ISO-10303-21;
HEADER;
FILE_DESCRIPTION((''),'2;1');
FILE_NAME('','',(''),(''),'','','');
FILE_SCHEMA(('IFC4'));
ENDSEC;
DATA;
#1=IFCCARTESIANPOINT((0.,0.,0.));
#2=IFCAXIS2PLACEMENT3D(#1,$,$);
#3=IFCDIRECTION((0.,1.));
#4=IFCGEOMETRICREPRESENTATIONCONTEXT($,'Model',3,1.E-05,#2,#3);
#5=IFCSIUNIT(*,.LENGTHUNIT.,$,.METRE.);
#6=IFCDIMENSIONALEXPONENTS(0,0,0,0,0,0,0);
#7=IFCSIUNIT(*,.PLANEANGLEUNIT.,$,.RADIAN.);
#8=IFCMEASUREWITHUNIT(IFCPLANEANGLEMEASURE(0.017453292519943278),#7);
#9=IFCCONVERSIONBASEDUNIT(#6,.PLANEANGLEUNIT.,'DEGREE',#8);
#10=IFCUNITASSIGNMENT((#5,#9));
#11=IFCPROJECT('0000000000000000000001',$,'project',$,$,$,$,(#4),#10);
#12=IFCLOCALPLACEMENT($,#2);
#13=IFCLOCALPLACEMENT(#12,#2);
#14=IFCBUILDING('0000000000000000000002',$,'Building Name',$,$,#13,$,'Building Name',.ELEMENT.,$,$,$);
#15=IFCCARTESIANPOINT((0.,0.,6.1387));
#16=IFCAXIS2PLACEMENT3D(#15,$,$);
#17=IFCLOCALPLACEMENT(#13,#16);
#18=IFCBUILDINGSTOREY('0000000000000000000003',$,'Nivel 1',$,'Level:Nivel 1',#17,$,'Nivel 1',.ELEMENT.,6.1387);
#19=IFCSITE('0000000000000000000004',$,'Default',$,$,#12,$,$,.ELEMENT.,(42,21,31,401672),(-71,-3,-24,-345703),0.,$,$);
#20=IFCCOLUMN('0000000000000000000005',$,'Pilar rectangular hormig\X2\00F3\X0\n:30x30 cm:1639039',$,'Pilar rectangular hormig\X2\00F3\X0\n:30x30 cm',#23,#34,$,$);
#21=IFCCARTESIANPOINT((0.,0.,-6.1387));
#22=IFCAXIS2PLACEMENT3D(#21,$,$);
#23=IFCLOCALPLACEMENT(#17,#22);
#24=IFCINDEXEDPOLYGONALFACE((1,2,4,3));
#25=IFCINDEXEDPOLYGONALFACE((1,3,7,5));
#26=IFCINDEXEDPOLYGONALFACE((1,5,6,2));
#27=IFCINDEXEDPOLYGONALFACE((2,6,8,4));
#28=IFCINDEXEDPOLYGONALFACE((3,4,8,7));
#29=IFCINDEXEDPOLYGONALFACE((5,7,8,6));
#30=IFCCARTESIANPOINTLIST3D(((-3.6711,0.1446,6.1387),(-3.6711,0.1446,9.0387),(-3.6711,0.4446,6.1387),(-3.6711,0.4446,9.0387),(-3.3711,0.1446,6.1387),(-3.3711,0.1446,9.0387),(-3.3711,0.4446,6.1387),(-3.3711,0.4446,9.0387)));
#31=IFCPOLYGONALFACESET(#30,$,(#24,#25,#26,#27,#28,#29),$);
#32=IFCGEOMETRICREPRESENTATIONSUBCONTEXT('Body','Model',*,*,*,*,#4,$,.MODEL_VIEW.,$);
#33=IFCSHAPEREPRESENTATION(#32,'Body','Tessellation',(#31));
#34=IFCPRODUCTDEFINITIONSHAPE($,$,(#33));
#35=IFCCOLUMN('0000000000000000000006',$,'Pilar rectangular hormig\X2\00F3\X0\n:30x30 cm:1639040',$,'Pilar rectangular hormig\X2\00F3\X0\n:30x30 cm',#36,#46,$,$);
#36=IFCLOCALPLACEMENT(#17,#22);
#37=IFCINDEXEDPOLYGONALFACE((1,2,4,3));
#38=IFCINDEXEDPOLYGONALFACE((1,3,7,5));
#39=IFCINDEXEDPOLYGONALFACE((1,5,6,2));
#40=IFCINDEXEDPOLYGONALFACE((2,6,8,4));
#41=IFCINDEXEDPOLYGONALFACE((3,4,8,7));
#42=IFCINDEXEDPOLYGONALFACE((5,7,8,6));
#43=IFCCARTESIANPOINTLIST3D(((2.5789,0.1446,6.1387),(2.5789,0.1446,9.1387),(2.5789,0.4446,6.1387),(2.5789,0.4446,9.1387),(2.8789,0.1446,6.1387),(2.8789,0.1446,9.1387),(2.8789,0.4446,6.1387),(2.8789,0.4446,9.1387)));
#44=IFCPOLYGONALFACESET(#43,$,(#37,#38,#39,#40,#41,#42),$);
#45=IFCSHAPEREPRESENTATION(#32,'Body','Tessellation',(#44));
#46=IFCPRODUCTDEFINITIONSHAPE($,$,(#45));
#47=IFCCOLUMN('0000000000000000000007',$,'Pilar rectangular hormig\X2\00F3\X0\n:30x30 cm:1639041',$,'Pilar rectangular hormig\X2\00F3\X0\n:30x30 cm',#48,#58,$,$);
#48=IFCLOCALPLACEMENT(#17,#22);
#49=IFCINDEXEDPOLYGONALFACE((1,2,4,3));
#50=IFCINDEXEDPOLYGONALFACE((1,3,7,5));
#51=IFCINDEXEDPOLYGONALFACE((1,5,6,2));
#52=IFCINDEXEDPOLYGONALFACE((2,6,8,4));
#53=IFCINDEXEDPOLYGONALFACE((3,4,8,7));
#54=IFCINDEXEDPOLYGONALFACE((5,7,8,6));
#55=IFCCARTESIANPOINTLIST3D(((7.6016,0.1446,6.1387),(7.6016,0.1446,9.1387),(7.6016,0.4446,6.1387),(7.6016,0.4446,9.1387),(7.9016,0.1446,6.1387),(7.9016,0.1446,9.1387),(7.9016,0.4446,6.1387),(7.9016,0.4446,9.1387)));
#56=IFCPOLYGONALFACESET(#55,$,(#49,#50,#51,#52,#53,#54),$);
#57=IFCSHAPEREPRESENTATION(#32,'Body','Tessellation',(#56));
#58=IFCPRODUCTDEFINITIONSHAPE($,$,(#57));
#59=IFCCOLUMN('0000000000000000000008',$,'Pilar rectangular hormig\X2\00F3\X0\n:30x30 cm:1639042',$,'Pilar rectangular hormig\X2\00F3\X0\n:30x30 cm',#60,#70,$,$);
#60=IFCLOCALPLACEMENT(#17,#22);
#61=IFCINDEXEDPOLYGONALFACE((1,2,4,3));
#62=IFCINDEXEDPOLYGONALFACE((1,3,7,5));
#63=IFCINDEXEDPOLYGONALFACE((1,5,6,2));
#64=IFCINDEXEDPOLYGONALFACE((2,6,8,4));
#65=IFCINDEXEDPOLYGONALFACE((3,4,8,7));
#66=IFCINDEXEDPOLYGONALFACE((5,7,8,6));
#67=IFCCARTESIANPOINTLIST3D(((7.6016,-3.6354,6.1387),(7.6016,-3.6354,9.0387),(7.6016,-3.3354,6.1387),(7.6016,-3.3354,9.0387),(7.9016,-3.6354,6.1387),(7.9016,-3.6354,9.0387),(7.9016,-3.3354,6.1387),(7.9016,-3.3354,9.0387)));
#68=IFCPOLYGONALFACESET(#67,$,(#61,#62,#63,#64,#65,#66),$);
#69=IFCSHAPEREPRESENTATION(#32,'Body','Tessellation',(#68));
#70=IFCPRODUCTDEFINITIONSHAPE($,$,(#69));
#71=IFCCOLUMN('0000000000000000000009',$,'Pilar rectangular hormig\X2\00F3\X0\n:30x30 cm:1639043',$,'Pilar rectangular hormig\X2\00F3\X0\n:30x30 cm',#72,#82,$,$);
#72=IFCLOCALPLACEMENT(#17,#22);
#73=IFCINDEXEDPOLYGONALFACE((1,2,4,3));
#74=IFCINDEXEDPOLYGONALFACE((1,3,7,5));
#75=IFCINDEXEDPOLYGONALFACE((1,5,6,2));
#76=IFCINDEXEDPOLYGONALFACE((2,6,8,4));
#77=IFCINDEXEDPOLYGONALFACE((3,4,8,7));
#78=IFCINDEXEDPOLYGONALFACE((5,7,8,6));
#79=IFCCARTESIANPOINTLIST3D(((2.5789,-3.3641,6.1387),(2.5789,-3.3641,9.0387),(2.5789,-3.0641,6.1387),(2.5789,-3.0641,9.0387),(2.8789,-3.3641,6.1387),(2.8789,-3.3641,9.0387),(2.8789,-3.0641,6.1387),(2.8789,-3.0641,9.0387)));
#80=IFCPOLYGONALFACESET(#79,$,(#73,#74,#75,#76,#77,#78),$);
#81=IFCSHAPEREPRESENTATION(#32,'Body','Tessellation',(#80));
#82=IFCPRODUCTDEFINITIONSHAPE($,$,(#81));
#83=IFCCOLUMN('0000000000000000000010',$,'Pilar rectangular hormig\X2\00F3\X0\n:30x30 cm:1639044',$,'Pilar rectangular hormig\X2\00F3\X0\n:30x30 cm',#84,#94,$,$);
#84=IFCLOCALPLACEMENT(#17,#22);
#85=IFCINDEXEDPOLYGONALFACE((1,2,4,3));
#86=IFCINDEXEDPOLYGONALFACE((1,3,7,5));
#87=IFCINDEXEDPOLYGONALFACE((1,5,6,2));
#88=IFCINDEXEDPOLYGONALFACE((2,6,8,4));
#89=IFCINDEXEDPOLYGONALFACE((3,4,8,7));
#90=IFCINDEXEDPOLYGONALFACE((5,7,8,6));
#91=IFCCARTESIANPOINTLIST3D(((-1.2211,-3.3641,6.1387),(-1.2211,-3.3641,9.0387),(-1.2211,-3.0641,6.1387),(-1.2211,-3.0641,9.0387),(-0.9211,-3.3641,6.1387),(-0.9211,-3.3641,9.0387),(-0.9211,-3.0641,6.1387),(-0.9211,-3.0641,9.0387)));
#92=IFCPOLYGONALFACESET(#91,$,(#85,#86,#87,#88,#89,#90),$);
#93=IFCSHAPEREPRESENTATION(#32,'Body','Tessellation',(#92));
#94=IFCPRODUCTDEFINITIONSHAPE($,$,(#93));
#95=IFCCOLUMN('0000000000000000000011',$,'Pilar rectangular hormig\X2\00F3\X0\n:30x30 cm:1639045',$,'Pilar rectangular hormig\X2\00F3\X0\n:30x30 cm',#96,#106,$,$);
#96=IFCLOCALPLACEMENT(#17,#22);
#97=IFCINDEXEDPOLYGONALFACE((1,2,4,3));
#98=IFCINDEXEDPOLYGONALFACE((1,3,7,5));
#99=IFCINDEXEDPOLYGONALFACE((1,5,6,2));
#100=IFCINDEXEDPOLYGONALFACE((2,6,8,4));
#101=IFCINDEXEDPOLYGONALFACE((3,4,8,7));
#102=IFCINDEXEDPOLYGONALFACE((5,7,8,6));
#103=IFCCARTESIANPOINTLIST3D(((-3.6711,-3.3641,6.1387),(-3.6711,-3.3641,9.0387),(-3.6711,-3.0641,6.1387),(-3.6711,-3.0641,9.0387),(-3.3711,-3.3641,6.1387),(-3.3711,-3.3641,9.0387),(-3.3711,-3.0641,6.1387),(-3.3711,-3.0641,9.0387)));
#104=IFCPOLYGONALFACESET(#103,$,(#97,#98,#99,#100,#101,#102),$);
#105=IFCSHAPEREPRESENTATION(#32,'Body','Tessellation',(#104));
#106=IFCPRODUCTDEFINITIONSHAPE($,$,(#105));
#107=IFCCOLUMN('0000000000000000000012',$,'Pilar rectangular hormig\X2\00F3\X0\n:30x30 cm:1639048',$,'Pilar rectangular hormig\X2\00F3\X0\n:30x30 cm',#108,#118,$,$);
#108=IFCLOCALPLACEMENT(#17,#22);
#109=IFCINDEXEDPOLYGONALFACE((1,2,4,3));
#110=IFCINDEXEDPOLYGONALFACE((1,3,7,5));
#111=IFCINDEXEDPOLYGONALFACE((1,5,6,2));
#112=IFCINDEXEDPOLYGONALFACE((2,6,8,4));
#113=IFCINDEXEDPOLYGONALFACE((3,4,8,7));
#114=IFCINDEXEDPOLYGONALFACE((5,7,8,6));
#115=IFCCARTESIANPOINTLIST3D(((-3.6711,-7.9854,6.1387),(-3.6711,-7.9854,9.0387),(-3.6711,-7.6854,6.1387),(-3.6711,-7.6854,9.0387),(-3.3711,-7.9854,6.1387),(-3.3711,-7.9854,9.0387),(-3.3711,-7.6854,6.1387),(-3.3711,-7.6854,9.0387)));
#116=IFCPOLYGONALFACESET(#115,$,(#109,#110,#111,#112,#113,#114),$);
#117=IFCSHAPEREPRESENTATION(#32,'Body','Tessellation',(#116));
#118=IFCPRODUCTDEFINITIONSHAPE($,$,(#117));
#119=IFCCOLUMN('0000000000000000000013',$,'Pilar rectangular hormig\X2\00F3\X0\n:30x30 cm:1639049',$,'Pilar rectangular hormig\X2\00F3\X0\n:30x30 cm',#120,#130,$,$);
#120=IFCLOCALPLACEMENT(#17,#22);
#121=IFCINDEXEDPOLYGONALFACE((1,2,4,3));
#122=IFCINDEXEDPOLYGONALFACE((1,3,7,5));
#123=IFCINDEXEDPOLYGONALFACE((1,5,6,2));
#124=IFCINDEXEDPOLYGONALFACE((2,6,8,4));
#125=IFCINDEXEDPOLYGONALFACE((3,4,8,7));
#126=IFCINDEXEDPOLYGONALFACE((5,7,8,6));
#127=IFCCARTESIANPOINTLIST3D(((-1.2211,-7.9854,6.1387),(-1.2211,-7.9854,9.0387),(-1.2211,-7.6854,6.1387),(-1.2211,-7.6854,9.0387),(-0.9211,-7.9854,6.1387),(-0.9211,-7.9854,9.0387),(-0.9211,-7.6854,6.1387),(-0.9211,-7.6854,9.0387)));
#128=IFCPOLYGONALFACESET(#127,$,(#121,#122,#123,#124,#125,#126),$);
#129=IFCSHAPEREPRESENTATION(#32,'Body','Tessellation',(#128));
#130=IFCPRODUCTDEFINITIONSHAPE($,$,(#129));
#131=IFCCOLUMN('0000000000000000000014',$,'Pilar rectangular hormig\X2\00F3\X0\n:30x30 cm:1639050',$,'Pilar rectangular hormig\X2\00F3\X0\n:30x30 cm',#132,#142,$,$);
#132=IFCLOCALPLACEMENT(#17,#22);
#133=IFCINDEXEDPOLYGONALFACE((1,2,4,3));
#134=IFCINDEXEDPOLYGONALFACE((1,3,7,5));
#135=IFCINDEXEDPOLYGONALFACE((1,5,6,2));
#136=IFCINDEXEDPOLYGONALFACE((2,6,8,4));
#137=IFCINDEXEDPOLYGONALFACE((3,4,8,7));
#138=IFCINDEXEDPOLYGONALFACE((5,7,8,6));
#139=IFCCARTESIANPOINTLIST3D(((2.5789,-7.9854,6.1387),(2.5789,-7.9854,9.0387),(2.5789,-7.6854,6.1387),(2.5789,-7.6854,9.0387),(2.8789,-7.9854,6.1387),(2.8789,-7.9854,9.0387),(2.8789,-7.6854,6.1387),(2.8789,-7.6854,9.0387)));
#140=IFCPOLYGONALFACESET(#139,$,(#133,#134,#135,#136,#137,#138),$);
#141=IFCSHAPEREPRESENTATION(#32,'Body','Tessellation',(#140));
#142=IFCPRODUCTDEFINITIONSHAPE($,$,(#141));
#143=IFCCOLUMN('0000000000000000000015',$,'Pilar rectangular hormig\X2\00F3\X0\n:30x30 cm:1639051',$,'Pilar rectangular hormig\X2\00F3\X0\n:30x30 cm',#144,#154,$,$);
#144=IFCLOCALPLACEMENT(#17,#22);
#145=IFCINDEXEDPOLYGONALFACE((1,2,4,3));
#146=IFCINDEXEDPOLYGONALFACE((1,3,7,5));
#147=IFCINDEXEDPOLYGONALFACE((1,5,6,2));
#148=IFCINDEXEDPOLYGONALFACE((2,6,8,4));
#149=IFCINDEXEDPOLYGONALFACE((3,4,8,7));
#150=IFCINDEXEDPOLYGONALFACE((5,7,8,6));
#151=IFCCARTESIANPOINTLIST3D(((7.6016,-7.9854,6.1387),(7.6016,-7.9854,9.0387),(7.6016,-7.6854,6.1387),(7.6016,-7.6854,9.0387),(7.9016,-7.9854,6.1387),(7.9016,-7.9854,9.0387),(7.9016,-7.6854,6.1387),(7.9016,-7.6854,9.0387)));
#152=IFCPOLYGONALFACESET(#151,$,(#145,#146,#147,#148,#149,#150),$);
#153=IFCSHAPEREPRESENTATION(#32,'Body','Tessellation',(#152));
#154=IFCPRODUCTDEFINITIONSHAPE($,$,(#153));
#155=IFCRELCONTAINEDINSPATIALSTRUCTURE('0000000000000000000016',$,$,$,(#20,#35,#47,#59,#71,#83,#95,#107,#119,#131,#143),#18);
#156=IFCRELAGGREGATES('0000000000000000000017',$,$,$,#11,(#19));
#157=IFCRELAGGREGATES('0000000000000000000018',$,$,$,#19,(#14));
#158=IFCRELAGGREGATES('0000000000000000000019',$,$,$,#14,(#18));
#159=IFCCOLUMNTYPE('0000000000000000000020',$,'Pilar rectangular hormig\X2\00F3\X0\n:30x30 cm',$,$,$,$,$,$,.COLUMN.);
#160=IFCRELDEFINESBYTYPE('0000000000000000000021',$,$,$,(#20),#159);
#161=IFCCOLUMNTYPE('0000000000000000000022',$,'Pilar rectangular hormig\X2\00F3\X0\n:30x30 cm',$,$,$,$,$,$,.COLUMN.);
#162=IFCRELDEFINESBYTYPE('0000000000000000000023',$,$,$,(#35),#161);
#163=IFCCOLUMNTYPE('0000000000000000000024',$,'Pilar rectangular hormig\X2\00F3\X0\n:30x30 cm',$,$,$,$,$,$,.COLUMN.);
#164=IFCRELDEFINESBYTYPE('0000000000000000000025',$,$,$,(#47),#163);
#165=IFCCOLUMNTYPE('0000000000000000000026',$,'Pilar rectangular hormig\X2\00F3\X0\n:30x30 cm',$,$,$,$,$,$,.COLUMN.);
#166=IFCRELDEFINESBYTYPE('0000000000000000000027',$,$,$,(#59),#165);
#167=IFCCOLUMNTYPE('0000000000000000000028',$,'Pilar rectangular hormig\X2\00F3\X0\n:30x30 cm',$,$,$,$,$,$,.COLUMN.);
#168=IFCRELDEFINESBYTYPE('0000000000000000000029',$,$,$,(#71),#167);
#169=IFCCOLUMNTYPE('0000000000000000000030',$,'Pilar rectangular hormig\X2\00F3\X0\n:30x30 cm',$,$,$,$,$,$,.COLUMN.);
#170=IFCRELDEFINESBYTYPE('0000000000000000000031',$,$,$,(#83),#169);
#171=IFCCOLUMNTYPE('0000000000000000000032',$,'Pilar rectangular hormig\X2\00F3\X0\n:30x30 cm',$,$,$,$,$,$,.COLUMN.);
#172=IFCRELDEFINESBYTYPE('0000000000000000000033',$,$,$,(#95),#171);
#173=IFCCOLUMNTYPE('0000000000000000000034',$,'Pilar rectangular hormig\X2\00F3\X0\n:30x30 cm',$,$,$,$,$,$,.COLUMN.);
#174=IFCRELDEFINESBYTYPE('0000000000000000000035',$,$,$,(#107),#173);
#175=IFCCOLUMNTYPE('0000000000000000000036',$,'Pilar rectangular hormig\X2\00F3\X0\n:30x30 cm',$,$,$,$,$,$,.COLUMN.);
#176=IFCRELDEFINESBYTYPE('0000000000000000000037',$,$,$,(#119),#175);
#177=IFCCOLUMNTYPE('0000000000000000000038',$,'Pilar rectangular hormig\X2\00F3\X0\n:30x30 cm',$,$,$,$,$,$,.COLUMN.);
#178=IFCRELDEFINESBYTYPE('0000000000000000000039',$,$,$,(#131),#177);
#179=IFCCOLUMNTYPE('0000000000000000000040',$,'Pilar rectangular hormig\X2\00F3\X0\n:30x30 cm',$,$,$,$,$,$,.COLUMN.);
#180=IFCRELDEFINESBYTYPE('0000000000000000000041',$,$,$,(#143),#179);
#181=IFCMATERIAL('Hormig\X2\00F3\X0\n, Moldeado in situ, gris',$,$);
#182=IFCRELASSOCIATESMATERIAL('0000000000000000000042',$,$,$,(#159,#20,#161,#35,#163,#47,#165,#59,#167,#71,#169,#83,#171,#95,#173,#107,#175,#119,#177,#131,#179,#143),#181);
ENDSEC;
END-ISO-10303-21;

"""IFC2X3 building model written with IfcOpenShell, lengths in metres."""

from ifc_helpers import new_model, entity, si_unit, converted_unit, direction, frame, frame_2d, origin, origin_2d_with_axis, place, context, subcontext, project, spatial, rectangle, extrude, source, transform, mapped, material, type_object, type_shapes, element, save


model = new_model("IFC2X3")

# Units and contexts
model_context = context("Model", 3, precision=1e-05, world=origin(), true_north=direction((0.0, 1.0)))
body_context = subcontext(model_context, "Body", "Model", "MODEL_VIEW")
ifc_project = project(units=[si_unit("LENGTHUNIT", "METRE"), converted_unit("PLANEANGLEUNIT", "DEGREE", entity("IfcPlaneAngleMeasure", 0.017453292519943278), si_unit("PLANEANGLEUNIT", "RADIAN"), dimensions=[0, 0, 0, 0, 0, 0, 0])], contexts=[model_context])

# Site, building, storey
site_placement = place(None, origin())
site = spatial("IfcSite", under=ifc_project, at=site_placement, Name="Default", CompositionType="ELEMENT", RefLatitude=(42, 21, 31, 401672), RefLongitude=(-71, -3, -24, -345703), RefElevation=0.0)
building_placement = place(site_placement, origin())
building = spatial("IfcBuilding", under=site, at=building_placement, Name="Building Name", LongName="Building Name", CompositionType="ELEMENT")
storey_placement = place(building_placement, frame((0.0, 0.0, 6.1387)))
storey = spatial("IfcBuildingStorey", under=building, at=storey_placement, Name="Nivel 1", ObjectType="Level:Nivel 1", LongName="Nivel 1", CompositionType="ELEMENT", Elevation=6.1387)

# Columns
ifc_material_1 = material(Name="Hormigón, Moldeado in situ, gris")
column_type_1 = type_object("IfcColumnType", Name="Pilar rectangular hormigón:30x30 cm", PredefinedType="COLUMN", material=ifc_material_1)
shared_shape_1 = source(origin(), body_context, "Body", "SweptSolid", [
    extrude(rectangle(XDim=0.3, YDim=0.3, at=origin_2d_with_axis()), frame((-3.5211, 0.2946, 6.1387), z_axis=(0.0, 0.0, 1.0), x_axis=(-1.0, 0.0, 0.0)), (0.0, 0.0, 1.0), 2.9),
])
type_shapes(column_type_1, [shared_shape_1])
column_1_placement = place(storey_placement, frame((0.0, 0.0, -6.1387)))
element("IfcColumn", 1, at=column_1_placement, inside=storey, type_object=column_type_1, material=ifc_material_1, Name="Pilar rectangular hormigón:30x30 cm:1639039", ObjectType="Pilar rectangular hormigón:30x30 cm", context=body_context, shape_type="MappedRepresentation", body=[
    mapped(shared_shape_1, transform((0.0, 0.0, 0.0), scale=1.0)),
])
column_type_2 = type_object("IfcColumnType", Name="Pilar rectangular hormigón:30x30 cm", PredefinedType="COLUMN", material=ifc_material_1)
shared_shape_2 = source(origin(), body_context, "Body", "SweptSolid", [
    extrude(rectangle(XDim=0.3, YDim=0.3, at=origin_2d_with_axis()), frame((2.7289, 0.2946, 6.1387), z_axis=(0.0, 0.0, 1.0), x_axis=(-1.0, 0.0, 0.0)), (0.0, 0.0, 1.0), 3.0),
])
type_shapes(column_type_2, [shared_shape_2])
column_2_placement = place(storey_placement, frame((0.0, 0.0, -6.1387)))
element("IfcColumn", 2, at=column_2_placement, inside=storey, type_object=column_type_2, material=ifc_material_1, Name="Pilar rectangular hormigón:30x30 cm:1639040", ObjectType="Pilar rectangular hormigón:30x30 cm", context=body_context, shape_type="MappedRepresentation", body=[
    mapped(shared_shape_2, transform((0.0, 0.0, 0.0), scale=1.0)),
])
column_type_3 = type_object("IfcColumnType", Name="Pilar rectangular hormigón:30x30 cm", PredefinedType="COLUMN", material=ifc_material_1)
shared_shape_3 = source(origin(), body_context, "Body", "SweptSolid", [
    extrude(rectangle(XDim=0.3, YDim=0.3, at=frame_2d((0.0, 0.0), x_axis=(1.0, 0.0))), frame((7.7516, 0.2946, 6.1387), z_axis=(0.0, 0.0, 1.0), x_axis=(-1.0, 0.0, 0.0)), (0.0, 0.0, 1.0), 3.0),
])
type_shapes(column_type_3, [shared_shape_3])
column_3_placement = place(storey_placement, frame((0.0, 0.0, -6.1387)))
element("IfcColumn", 3, at=column_3_placement, inside=storey, type_object=column_type_3, material=ifc_material_1, Name="Pilar rectangular hormigón:30x30 cm:1639041", ObjectType="Pilar rectangular hormigón:30x30 cm", context=body_context, shape_type="MappedRepresentation", body=[
    mapped(shared_shape_3, transform((0.0, 0.0, 0.0), scale=1.0)),
])
column_type_4 = type_object("IfcColumnType", Name="Pilar rectangular hormigón:30x30 cm", PredefinedType="COLUMN", material=ifc_material_1)
shared_shape_4 = source(origin(), body_context, "Body", "SweptSolid", [
    extrude(rectangle(XDim=0.3, YDim=0.3, at=frame_2d((0.0, 0.0), x_axis=(1.0, 0.0))), frame((7.7516, -3.4854, 6.1387), z_axis=(0.0, 0.0, 1.0), x_axis=(-1.0, 0.0, 0.0)), (0.0, 0.0, 1.0), 2.9),
])
type_shapes(column_type_4, [shared_shape_4])
column_4_placement = place(storey_placement, frame((0.0, 0.0, -6.1387)))
element("IfcColumn", 4, at=column_4_placement, inside=storey, type_object=column_type_4, material=ifc_material_1, Name="Pilar rectangular hormigón:30x30 cm:1639042", ObjectType="Pilar rectangular hormigón:30x30 cm", context=body_context, shape_type="MappedRepresentation", body=[
    mapped(shared_shape_4, transform((0.0, 0.0, 0.0), scale=1.0)),
])
column_type_5 = type_object("IfcColumnType", Name="Pilar rectangular hormigón:30x30 cm", PredefinedType="COLUMN", material=ifc_material_1)
shared_shape_5 = source(origin(), body_context, "Body", "SweptSolid", [
    extrude(rectangle(XDim=0.3, YDim=0.3, at=origin_2d_with_axis()), frame((2.7289, -3.2141, 6.1387), z_axis=(0.0, 0.0, 1.0), x_axis=(-1.0, 0.0, 0.0)), (0.0, 0.0, 1.0), 2.9),
])
type_shapes(column_type_5, [shared_shape_5])
column_5_placement = place(storey_placement, frame((0.0, 0.0, -6.1387)))
element("IfcColumn", 5, at=column_5_placement, inside=storey, type_object=column_type_5, material=ifc_material_1, Name="Pilar rectangular hormigón:30x30 cm:1639043", ObjectType="Pilar rectangular hormigón:30x30 cm", context=body_context, shape_type="MappedRepresentation", body=[
    mapped(shared_shape_5, transform((0.0, 0.0, 0.0), scale=1.0)),
])
column_type_6 = type_object("IfcColumnType", Name="Pilar rectangular hormigón:30x30 cm", PredefinedType="COLUMN", material=ifc_material_1)
shared_shape_6 = source(origin(), body_context, "Body", "SweptSolid", [
    extrude(rectangle(XDim=0.3, YDim=0.3, at=origin_2d_with_axis()), frame((-1.0711, -3.2141, 6.1387), z_axis=(0.0, 0.0, 1.0), x_axis=(-1.0, 0.0, 0.0)), (0.0, 0.0, 1.0), 2.9),
])
type_shapes(column_type_6, [shared_shape_6])
column_6_placement = place(storey_placement, frame((0.0, 0.0, -6.1387)))
element("IfcColumn", 6, at=column_6_placement, inside=storey, type_object=column_type_6, material=ifc_material_1, Name="Pilar rectangular hormigón:30x30 cm:1639044", ObjectType="Pilar rectangular hormigón:30x30 cm", context=body_context, shape_type="MappedRepresentation", body=[
    mapped(shared_shape_6, transform((0.0, 0.0, 0.0), scale=1.0)),
])
column_type_7 = type_object("IfcColumnType", Name="Pilar rectangular hormigón:30x30 cm", PredefinedType="COLUMN", material=ifc_material_1)
shared_shape_7 = source(origin(), body_context, "Body", "SweptSolid", [
    extrude(rectangle(XDim=0.3, YDim=0.3, at=origin_2d_with_axis()), frame((-3.5211, -3.2141, 6.1387), z_axis=(0.0, 0.0, 1.0), x_axis=(-1.0, 0.0, 0.0)), (0.0, 0.0, 1.0), 2.9),
])
type_shapes(column_type_7, [shared_shape_7])
column_7_placement = place(storey_placement, frame((0.0, 0.0, -6.1387)))
element("IfcColumn", 7, at=column_7_placement, inside=storey, type_object=column_type_7, material=ifc_material_1, Name="Pilar rectangular hormigón:30x30 cm:1639045", ObjectType="Pilar rectangular hormigón:30x30 cm", context=body_context, shape_type="MappedRepresentation", body=[
    mapped(shared_shape_7, transform((0.0, 0.0, 0.0), scale=1.0)),
])
column_type_8 = type_object("IfcColumnType", Name="Pilar rectangular hormigón:30x30 cm", PredefinedType="COLUMN", material=ifc_material_1)
shared_shape_8 = source(origin(), body_context, "Body", "SweptSolid", [
    extrude(rectangle(XDim=0.3, YDim=0.3, at=frame_2d((0.0, 0.0), x_axis=(1.0, 0.0))), frame((-3.5211, -7.8354, 6.1387), z_axis=(0.0, 0.0, 1.0), x_axis=(-1.0, 0.0, 0.0)), (0.0, 0.0, 1.0), 2.9),
])
type_shapes(column_type_8, [shared_shape_8])
column_8_placement = place(storey_placement, frame((0.0, 0.0, -6.1387)))
element("IfcColumn", 8, at=column_8_placement, inside=storey, type_object=column_type_8, material=ifc_material_1, Name="Pilar rectangular hormigón:30x30 cm:1639048", ObjectType="Pilar rectangular hormigón:30x30 cm", context=body_context, shape_type="MappedRepresentation", body=[
    mapped(shared_shape_8, transform((0.0, 0.0, 0.0), scale=1.0)),
])
column_type_9 = type_object("IfcColumnType", Name="Pilar rectangular hormigón:30x30 cm", PredefinedType="COLUMN", material=ifc_material_1)
shared_shape_9 = source(origin(), body_context, "Body", "SweptSolid", [
    extrude(rectangle(XDim=0.3, YDim=0.3, at=frame_2d((0.0, 0.0), x_axis=(1.0, 0.0))), frame((-1.0711, -7.8354, 6.1387), z_axis=(0.0, 0.0, 1.0), x_axis=(-1.0, 0.0, 0.0)), (0.0, 0.0, 1.0), 2.9),
])
type_shapes(column_type_9, [shared_shape_9])
column_9_placement = place(storey_placement, frame((0.0, 0.0, -6.1387)))
element("IfcColumn", 9, at=column_9_placement, inside=storey, type_object=column_type_9, material=ifc_material_1, Name="Pilar rectangular hormigón:30x30 cm:1639049", ObjectType="Pilar rectangular hormigón:30x30 cm", context=body_context, shape_type="MappedRepresentation", body=[
    mapped(shared_shape_9, transform((0.0, 0.0, 0.0), scale=1.0)),
])
column_type_10 = type_object("IfcColumnType", Name="Pilar rectangular hormigón:30x30 cm", PredefinedType="COLUMN", material=ifc_material_1)
shared_shape_10 = source(origin(), body_context, "Body", "SweptSolid", [
    extrude(rectangle(XDim=0.3, YDim=0.3, at=frame_2d((0.0, 0.0), x_axis=(1.0, 0.0))), frame((2.7289, -7.8354, 6.1387), z_axis=(0.0, 0.0, 1.0), x_axis=(-1.0, 0.0, 0.0)), (0.0, 0.0, 1.0), 2.9),
])
type_shapes(column_type_10, [shared_shape_10])
column_10_placement = place(storey_placement, frame((0.0, 0.0, -6.1387)))
element("IfcColumn", 10, at=column_10_placement, inside=storey, type_object=column_type_10, material=ifc_material_1, Name="Pilar rectangular hormigón:30x30 cm:1639050", ObjectType="Pilar rectangular hormigón:30x30 cm", context=body_context, shape_type="MappedRepresentation", body=[
    mapped(shared_shape_10, transform((0.0, 0.0, 0.0), scale=1.0)),
])
column_type_11 = type_object("IfcColumnType", Name="Pilar rectangular hormigón:30x30 cm", PredefinedType="COLUMN", material=ifc_material_1)
shared_shape_11 = source(origin(), body_context, "Body", "SweptSolid", [
    extrude(rectangle(XDim=0.3, YDim=0.3, at=frame_2d((0.0, 0.0), x_axis=(1.0, 0.0))), frame((7.7516, -7.8354, 6.1387), z_axis=(0.0, 0.0, 1.0), x_axis=(-1.0, 0.0, 0.0)), (0.0, 0.0, 1.0), 2.9),
])
type_shapes(column_type_11, [shared_shape_11])
column_11_placement = place(storey_placement, frame((0.0, 0.0, -6.1387)))
element("IfcColumn", 11, at=column_11_placement, inside=storey, type_object=column_type_11, material=ifc_material_1, Name="Pilar rectangular hormigón:30x30 cm:1639051", ObjectType="Pilar rectangular hormigón:30x30 cm", context=body_context, shape_type="MappedRepresentation", body=[
    mapped(shared_shape_11, transform((0.0, 0.0, 0.0), scale=1.0)),
])

save(model, "model.ifc")
